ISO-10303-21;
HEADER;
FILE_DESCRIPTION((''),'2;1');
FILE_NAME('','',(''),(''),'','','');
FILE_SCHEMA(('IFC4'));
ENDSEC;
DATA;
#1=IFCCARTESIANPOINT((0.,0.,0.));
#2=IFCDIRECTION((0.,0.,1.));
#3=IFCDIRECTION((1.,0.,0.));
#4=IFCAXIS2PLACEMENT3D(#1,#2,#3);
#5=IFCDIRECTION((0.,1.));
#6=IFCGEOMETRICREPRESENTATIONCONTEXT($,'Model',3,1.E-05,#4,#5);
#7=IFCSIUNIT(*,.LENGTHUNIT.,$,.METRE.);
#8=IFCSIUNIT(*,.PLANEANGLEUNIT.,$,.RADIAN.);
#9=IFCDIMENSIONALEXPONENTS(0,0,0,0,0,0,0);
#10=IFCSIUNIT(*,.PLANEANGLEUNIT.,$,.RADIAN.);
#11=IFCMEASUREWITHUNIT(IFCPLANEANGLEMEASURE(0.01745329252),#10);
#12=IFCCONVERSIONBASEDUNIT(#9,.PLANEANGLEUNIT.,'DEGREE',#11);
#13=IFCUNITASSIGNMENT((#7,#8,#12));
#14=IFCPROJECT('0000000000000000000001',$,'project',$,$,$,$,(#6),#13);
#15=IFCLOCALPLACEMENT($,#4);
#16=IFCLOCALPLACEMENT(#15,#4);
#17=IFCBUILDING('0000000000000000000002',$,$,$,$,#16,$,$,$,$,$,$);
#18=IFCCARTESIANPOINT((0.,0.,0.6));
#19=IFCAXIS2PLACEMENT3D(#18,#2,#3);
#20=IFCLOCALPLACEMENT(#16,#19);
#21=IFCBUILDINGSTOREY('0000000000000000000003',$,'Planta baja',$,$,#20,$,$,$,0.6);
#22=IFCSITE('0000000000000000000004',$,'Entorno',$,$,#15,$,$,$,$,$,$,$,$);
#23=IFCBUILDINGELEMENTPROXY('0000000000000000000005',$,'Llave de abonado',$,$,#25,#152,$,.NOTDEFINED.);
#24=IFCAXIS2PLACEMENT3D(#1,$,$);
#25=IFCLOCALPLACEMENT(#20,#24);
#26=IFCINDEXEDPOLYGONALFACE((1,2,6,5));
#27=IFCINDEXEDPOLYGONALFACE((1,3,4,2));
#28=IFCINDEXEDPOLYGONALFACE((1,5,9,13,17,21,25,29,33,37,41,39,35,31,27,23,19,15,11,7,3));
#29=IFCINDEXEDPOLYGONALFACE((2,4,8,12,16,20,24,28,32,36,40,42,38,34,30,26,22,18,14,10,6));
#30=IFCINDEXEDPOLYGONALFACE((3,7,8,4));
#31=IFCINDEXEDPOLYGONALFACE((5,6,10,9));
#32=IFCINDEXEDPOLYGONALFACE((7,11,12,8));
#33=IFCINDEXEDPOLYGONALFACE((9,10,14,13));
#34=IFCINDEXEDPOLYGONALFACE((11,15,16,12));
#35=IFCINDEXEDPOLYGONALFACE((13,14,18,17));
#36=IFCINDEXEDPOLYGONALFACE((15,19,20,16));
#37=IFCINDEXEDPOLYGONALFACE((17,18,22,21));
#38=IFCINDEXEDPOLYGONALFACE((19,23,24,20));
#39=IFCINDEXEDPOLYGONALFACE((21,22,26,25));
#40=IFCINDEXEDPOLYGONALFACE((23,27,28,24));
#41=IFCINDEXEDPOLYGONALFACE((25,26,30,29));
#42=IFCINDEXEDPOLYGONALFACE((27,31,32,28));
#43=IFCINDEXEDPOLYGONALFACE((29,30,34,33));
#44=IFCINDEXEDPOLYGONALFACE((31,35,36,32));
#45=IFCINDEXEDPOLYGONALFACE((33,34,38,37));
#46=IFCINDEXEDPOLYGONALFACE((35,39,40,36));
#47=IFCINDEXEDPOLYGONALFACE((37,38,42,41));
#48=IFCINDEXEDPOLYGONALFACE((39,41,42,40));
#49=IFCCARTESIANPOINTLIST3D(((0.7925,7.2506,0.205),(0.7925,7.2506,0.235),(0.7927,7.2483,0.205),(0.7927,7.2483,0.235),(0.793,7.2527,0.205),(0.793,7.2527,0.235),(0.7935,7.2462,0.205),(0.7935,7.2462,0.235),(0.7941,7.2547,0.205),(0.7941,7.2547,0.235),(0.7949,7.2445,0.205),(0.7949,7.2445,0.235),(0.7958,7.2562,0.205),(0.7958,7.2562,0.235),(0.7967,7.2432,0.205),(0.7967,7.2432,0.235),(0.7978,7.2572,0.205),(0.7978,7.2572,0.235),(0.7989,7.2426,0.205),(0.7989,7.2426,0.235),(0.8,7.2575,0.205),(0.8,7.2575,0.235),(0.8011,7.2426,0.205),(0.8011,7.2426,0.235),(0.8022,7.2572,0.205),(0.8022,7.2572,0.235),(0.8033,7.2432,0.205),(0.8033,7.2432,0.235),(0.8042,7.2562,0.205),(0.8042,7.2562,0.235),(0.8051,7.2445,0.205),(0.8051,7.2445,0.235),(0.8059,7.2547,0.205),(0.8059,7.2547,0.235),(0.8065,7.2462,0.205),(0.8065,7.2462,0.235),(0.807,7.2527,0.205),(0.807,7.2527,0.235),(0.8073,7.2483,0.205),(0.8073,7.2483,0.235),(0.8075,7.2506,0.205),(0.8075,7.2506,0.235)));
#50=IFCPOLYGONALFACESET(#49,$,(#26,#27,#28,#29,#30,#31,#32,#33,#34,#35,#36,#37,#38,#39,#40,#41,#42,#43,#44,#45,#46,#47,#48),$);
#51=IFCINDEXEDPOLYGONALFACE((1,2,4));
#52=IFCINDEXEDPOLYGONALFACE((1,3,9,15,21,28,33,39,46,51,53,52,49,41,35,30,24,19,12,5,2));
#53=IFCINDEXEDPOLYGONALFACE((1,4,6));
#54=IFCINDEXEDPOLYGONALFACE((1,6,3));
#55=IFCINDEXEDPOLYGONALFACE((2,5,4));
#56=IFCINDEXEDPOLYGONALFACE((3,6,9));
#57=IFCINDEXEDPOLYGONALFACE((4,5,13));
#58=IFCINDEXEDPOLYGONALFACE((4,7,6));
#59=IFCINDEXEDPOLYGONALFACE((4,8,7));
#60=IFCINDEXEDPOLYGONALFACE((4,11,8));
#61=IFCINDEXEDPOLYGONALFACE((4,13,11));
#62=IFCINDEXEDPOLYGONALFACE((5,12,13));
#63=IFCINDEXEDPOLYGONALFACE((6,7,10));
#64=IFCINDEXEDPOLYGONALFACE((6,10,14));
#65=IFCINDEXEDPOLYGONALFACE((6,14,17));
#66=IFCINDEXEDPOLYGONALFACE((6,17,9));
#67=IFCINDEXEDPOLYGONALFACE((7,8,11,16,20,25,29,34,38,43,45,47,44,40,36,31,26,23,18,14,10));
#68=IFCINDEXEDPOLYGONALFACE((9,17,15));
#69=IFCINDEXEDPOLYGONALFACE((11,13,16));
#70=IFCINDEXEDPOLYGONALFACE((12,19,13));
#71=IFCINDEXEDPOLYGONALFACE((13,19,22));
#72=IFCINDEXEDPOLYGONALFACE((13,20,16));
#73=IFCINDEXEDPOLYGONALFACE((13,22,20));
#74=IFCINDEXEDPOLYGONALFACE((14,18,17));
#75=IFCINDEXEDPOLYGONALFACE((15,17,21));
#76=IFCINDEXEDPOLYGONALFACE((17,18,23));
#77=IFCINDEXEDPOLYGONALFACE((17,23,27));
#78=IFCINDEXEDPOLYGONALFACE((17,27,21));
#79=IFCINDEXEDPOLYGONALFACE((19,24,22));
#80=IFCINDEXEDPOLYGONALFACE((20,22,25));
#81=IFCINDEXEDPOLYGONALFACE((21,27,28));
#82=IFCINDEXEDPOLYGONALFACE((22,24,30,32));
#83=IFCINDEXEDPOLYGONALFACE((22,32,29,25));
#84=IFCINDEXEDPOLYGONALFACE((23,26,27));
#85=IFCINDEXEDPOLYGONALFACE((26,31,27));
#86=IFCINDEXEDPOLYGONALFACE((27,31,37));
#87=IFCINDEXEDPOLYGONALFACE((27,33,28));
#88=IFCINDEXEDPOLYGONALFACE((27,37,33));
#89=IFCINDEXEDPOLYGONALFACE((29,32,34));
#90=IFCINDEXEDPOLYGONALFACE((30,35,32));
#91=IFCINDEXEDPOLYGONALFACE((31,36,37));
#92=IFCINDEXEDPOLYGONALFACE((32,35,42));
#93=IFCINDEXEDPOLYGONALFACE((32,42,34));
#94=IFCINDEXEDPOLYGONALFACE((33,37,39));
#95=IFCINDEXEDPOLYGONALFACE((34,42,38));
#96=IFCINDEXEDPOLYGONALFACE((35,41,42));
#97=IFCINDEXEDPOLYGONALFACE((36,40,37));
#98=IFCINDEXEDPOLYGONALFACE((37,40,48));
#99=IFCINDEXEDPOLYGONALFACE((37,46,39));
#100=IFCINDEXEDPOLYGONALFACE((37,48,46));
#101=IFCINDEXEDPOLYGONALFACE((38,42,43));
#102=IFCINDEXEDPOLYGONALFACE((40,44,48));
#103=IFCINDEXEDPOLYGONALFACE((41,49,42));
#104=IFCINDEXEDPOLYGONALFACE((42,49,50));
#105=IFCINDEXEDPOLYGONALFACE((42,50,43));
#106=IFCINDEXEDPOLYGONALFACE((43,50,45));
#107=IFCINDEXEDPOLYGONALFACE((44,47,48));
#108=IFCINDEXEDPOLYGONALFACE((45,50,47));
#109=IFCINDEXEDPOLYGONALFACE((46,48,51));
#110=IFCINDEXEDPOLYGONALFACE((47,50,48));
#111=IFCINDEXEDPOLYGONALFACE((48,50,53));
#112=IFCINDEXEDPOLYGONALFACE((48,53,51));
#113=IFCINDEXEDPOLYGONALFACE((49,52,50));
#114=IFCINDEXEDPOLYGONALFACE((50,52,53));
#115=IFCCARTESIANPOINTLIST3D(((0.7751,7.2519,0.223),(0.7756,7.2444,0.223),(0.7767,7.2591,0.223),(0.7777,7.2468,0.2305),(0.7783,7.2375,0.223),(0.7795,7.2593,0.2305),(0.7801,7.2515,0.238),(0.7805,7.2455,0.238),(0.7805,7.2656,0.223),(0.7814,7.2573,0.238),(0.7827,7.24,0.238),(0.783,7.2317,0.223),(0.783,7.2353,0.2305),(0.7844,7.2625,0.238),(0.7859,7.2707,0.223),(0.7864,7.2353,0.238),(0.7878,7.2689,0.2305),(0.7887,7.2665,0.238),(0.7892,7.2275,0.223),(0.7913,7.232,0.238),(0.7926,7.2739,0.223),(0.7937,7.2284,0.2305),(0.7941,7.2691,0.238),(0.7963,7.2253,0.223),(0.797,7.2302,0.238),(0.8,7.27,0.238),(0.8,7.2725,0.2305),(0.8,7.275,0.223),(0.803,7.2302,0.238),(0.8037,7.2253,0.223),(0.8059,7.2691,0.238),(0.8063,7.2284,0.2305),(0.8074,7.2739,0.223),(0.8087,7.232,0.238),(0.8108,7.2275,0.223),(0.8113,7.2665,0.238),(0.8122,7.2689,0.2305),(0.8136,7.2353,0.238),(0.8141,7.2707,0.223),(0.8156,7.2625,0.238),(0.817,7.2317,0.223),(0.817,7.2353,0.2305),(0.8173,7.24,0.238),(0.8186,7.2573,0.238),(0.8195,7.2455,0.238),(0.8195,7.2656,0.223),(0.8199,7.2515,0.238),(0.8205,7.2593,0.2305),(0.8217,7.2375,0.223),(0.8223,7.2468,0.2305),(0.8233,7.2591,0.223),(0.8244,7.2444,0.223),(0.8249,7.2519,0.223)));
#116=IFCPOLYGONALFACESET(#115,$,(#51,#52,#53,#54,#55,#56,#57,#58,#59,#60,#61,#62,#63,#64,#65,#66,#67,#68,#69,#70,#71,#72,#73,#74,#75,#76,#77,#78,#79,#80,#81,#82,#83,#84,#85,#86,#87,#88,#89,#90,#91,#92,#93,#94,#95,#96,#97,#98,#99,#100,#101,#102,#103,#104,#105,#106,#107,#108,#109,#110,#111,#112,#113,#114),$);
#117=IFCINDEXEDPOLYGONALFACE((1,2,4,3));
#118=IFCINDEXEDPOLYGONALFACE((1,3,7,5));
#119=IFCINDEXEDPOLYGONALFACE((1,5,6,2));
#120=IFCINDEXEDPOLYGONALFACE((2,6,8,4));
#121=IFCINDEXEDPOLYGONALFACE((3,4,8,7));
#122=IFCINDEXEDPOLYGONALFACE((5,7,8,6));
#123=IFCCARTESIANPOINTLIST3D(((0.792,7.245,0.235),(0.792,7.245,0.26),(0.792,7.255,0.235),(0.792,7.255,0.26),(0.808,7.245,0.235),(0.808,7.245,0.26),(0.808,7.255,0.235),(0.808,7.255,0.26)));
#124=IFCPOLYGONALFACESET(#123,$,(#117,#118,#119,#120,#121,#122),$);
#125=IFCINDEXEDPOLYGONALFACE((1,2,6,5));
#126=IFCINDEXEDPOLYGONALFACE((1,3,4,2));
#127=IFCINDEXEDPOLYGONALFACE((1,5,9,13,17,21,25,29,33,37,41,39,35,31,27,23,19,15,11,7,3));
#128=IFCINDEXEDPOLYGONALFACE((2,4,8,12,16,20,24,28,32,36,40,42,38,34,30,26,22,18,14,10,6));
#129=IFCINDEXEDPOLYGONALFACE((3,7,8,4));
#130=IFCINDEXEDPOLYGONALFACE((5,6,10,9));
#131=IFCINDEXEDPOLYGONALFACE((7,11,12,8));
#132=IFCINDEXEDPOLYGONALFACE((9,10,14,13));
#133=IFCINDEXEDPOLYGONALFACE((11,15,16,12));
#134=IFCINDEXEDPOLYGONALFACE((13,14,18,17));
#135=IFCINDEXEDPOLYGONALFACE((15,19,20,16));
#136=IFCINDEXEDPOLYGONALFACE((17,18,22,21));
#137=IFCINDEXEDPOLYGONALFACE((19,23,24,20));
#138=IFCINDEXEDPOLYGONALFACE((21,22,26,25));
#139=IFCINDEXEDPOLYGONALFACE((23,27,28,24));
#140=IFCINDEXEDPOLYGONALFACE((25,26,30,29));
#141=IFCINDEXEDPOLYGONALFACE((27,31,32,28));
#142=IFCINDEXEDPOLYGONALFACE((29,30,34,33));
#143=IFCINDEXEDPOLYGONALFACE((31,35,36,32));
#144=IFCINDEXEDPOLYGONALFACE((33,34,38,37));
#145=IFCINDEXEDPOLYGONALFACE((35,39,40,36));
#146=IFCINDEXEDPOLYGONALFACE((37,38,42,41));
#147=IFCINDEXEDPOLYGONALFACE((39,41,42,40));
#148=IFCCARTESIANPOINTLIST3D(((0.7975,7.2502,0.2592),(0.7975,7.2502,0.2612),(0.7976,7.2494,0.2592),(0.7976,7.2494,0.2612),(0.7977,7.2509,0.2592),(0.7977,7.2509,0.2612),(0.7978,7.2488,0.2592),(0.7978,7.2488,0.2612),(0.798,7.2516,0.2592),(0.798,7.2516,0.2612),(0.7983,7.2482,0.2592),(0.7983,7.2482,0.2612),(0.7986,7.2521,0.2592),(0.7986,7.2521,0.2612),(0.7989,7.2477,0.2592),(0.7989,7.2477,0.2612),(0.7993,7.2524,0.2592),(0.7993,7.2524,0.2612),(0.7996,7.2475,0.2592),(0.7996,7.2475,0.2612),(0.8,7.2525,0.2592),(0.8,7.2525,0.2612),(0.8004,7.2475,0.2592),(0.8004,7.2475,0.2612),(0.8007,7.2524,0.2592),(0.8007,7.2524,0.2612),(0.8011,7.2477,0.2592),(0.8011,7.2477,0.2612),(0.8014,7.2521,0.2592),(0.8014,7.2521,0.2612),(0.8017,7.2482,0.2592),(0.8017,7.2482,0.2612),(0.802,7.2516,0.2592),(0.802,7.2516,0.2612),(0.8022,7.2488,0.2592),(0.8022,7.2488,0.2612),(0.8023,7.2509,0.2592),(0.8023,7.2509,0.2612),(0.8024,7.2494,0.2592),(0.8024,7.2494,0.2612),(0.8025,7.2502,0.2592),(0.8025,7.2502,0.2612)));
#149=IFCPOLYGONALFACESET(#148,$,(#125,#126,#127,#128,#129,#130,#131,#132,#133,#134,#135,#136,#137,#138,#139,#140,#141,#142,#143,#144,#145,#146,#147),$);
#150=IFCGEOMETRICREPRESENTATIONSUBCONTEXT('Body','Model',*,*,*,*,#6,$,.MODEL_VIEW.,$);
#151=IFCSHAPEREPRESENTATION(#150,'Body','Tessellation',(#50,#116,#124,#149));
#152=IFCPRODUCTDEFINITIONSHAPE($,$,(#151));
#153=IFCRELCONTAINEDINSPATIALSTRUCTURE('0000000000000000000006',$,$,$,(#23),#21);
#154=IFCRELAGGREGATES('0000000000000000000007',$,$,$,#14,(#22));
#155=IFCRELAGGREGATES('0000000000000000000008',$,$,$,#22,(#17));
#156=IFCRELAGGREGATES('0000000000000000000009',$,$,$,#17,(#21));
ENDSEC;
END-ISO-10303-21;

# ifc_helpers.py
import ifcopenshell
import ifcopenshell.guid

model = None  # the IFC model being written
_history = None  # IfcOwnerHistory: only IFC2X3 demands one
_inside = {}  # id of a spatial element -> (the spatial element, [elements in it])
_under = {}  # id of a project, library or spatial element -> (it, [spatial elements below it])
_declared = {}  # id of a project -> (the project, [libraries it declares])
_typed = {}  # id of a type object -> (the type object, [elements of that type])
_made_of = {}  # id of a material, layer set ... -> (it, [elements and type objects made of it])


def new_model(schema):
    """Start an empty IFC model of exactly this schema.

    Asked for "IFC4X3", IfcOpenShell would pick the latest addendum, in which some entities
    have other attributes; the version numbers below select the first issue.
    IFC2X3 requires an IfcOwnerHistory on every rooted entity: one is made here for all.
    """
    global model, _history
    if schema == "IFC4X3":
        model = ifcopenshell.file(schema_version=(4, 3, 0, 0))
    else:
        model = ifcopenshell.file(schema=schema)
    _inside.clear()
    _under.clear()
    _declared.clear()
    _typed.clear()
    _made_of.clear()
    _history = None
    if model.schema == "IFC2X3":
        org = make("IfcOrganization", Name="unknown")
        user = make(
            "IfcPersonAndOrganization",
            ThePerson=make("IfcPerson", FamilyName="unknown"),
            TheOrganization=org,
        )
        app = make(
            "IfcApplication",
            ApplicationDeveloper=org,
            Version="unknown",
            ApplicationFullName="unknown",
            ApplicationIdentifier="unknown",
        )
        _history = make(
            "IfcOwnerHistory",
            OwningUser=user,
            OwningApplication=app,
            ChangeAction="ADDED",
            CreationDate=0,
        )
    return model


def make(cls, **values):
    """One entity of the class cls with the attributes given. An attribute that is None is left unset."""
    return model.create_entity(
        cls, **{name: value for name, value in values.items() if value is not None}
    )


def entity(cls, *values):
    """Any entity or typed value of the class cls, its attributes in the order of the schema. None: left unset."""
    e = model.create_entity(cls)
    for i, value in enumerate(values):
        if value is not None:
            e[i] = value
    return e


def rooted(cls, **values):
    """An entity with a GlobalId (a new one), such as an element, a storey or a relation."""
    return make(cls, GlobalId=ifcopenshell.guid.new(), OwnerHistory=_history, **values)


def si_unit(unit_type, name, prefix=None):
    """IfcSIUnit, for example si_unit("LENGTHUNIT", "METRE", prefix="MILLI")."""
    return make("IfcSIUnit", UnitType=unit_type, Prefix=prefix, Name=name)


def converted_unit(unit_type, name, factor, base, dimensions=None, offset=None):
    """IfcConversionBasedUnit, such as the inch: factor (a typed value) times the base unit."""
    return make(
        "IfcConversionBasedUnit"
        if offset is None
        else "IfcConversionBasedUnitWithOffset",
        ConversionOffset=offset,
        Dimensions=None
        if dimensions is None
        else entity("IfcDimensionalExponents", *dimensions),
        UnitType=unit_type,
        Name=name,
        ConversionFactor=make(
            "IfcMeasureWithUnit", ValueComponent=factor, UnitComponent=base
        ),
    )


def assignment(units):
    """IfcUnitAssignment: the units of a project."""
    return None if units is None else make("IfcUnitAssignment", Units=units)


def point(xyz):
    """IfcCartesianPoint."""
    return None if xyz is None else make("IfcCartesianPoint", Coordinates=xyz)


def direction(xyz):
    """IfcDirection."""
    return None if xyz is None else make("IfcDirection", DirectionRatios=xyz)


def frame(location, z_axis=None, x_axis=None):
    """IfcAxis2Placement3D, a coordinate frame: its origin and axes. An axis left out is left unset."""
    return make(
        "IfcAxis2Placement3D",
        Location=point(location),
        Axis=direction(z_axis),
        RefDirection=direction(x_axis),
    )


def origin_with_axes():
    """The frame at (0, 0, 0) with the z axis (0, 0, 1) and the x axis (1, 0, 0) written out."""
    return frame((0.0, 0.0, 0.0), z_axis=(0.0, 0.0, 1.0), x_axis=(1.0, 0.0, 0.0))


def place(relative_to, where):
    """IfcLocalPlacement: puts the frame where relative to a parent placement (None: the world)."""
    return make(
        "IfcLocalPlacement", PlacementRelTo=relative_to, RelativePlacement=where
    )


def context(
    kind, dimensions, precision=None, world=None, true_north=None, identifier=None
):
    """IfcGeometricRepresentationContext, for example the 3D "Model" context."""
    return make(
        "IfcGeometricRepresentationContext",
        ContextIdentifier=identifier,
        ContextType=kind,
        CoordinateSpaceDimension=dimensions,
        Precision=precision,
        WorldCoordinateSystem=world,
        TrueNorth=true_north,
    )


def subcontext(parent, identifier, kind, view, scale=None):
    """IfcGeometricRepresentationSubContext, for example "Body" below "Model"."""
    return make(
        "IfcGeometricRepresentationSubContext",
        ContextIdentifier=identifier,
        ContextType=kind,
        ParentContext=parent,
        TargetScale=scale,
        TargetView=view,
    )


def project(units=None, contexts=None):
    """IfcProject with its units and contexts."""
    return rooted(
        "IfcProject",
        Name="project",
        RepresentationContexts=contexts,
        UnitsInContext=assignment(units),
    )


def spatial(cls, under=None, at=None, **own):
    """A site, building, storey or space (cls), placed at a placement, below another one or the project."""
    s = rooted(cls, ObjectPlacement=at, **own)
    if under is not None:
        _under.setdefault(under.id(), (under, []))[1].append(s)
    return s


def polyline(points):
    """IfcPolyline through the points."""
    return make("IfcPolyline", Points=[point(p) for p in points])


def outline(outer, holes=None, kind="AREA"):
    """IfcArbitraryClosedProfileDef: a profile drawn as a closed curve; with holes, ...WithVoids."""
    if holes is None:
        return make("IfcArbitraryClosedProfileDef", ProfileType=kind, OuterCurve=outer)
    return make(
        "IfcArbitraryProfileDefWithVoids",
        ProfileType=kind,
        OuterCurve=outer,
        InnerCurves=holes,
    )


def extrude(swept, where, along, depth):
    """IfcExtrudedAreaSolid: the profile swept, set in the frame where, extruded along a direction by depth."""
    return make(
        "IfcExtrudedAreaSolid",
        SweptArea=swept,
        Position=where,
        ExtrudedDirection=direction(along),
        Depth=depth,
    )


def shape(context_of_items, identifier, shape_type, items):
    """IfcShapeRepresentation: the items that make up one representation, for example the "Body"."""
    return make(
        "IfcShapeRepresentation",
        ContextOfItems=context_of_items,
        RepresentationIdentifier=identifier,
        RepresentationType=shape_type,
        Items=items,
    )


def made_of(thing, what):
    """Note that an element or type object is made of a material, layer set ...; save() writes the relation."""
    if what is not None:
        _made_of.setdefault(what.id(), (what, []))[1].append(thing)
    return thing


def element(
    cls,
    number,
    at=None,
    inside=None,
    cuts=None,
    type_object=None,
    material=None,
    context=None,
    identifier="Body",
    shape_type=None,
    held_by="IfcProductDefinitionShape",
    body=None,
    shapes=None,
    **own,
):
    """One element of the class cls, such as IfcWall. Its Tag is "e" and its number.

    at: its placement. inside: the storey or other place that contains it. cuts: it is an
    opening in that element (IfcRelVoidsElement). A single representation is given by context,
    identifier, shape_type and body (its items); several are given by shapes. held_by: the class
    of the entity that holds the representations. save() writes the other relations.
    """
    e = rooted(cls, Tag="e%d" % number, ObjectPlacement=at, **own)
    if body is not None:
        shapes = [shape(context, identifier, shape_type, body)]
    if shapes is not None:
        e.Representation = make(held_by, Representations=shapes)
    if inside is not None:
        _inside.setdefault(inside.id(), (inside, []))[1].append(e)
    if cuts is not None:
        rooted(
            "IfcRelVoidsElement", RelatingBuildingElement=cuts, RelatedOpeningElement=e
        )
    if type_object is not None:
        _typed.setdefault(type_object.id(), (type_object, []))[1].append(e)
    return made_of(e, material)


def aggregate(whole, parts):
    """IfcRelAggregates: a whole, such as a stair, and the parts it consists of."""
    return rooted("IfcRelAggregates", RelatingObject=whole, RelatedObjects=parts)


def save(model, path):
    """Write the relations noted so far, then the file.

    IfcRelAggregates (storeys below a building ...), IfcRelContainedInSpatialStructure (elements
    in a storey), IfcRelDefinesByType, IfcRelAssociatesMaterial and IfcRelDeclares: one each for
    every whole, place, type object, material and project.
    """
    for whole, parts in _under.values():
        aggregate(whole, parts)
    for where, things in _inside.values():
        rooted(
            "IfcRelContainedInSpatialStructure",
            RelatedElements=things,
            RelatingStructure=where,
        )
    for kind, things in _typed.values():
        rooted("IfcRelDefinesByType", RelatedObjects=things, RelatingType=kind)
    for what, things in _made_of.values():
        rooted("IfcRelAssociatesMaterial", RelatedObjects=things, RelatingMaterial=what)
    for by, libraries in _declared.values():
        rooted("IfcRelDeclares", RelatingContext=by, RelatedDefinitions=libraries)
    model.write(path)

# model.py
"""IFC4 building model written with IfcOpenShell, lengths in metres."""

from ifc_helpers import new_model, entity, si_unit, converted_unit, direction, frame, origin_with_axes, place, context, subcontext, project, spatial, polyline, outline, extrude, element, save


model = new_model("IFC4")

# Units and contexts
model_context = context("Model", 3, precision=1e-05, world=origin_with_axes(), true_north=direction((0.0, 1.0)))
body_context = subcontext(model_context, "Body", "Model", "MODEL_VIEW")
ifc_project = project(units=[si_unit("LENGTHUNIT", "METRE"), si_unit("PLANEANGLEUNIT", "RADIAN"), converted_unit("PLANEANGLEUNIT", "DEGREE", entity("IfcPlaneAngleMeasure", 0.01745329252), si_unit("PLANEANGLEUNIT", "RADIAN"), dimensions=[0, 0, 0, 0, 0, 0, 0])], contexts=[model_context])

# Site, building, storey
site_placement = place(None, origin_with_axes())
site = spatial("IfcSite", under=ifc_project, at=site_placement, Name="Entorno")
building_placement = place(site_placement, origin_with_axes())
building = spatial("IfcBuilding", under=site, at=building_placement)
storey_placement = place(building_placement, frame((0.0, 0.0, 0.6), z_axis=(0.0, 0.0, 1.0), x_axis=(1.0, 0.0, 0.0)))
storey = spatial("IfcBuildingStorey", under=building, at=storey_placement, Name="Planta baja", Elevation=0.6)

# Building element proxy
proxy_1_placement = place(storey_placement, frame((0.0, 0.0, -0.6), z_axis=(0.0, 0.0, 1.0), x_axis=(1.0, 0.0, 0.0)))
ifc_direction_1 = entity("IfcDirection", [0.0, 0.0, 1.0])
ifc_direction_2 = entity("IfcDirection", [0.0, 0.0, 1.0])
ifc_direction_3 = entity("IfcDirection", [0.0, 0.0, 1.0])
element("IfcBuildingElementProxy", 1, at=proxy_1_placement, inside=storey, Name="Llave de abonado", PredefinedType="NOTDEFINED", context=body_context, shape_type="Brep", body=[
    entity("IfcExtrudedAreaSolidTapered", entity("IfcCircleProfileDef", "AREA", None, entity("IfcAxis2Placement2D", entity("IfcCartesianPoint", [0.0, 0.0]), entity("IfcDirection", [1.0, 0.0])), 0.0075), entity("IfcAxis2Placement3D", entity("IfcCartesianPoint", [0.8, 7.25, 0.805]), ifc_direction_1, entity("IfcDirection", [0.0, 1.0, 0.0])), ifc_direction_1, 0.03, entity("IfcCircleProfileDef", "AREA", None, entity("IfcAxis2Placement2D", entity("IfcCartesianPoint", [0.0, 0.0]), entity("IfcDirection", [1.0, 0.0])), 0.0075)),
    entity("IfcExtrudedAreaSolidTapered", entity("IfcCircleProfileDef", "AREA", None, entity("IfcAxis2Placement2D", entity("IfcCartesianPoint", [0.0, 0.0]), entity("IfcDirection", [1.0, 0.0])), 0.025), entity("IfcAxis2Placement3D", entity("IfcCartesianPoint", [0.8, 7.25, 0.823]), ifc_direction_2, entity("IfcDirection", [0.0, 1.0, 0.0])), ifc_direction_2, 0.015, entity("IfcCircleProfileDef", "AREA", None, entity("IfcAxis2Placement2D", entity("IfcCartesianPoint", [0.0, 0.0]), entity("IfcDirection", [1.0, 0.0])), 0.02)),
    extrude(outline(polyline([(0.005, -0.008), (0.005, 0.008), (-0.005, 0.008), (-0.005, -0.008), (0.005, -0.008)])), frame((0.8, 7.25, 0.835), z_axis=(0.0, 0.0, 1.0), x_axis=(0.0, 1.0, 0.0)), (0.0, 0.0, 1.0), 0.025),
    entity("IfcExtrudedAreaSolidTapered", entity("IfcCircleProfileDef", "AREA", None, entity("IfcAxis2Placement2D", entity("IfcCartesianPoint", [0.0, 0.0]), entity("IfcDirection", [1.0, 0.0])), 0.0025), entity("IfcAxis2Placement3D", entity("IfcCartesianPoint", [0.8, 7.25, 0.8592]), ifc_direction_3, entity("IfcDirection", [0.0, 1.0, 0.0])), ifc_direction_3, 0.002, entity("IfcCircleProfileDef", "AREA", None, entity("IfcAxis2Placement2D", entity("IfcCartesianPoint", [0.0, 0.0]), entity("IfcDirection", [1.0, 0.0])), 0.0025)),
    entity("IfcPolyline", [entity("IfcCartesianPoint", [0.8, 7.2512, 0.8612]), entity("IfcCartesianPoint", [0.7994, 7.2511, 0.8612]), entity("IfcCartesianPoint", [0.7989, 7.2506, 0.8612]), entity("IfcCartesianPoint", [0.7987, 7.25, 0.8612]), entity("IfcCartesianPoint", [0.7989, 7.2494, 0.8612]), entity("IfcCartesianPoint", [0.7994, 7.2489, 0.8612]), entity("IfcCartesianPoint", [0.8, 7.2488, 0.8612]), entity("IfcCartesianPoint", [0.8006, 7.2489, 0.8612]), entity("IfcCartesianPoint", [0.8011, 7.2494, 0.8612]), entity("IfcCartesianPoint", [0.8013, 7.25, 0.8612]), entity("IfcCartesianPoint", [0.8011, 7.2506, 0.8612]), entity("IfcCartesianPoint", [0.8006, 7.2511, 0.8612]), entity("IfcCartesianPoint", [0.8, 7.2512, 0.8612])]),
])

save(model, "model.ifc")
